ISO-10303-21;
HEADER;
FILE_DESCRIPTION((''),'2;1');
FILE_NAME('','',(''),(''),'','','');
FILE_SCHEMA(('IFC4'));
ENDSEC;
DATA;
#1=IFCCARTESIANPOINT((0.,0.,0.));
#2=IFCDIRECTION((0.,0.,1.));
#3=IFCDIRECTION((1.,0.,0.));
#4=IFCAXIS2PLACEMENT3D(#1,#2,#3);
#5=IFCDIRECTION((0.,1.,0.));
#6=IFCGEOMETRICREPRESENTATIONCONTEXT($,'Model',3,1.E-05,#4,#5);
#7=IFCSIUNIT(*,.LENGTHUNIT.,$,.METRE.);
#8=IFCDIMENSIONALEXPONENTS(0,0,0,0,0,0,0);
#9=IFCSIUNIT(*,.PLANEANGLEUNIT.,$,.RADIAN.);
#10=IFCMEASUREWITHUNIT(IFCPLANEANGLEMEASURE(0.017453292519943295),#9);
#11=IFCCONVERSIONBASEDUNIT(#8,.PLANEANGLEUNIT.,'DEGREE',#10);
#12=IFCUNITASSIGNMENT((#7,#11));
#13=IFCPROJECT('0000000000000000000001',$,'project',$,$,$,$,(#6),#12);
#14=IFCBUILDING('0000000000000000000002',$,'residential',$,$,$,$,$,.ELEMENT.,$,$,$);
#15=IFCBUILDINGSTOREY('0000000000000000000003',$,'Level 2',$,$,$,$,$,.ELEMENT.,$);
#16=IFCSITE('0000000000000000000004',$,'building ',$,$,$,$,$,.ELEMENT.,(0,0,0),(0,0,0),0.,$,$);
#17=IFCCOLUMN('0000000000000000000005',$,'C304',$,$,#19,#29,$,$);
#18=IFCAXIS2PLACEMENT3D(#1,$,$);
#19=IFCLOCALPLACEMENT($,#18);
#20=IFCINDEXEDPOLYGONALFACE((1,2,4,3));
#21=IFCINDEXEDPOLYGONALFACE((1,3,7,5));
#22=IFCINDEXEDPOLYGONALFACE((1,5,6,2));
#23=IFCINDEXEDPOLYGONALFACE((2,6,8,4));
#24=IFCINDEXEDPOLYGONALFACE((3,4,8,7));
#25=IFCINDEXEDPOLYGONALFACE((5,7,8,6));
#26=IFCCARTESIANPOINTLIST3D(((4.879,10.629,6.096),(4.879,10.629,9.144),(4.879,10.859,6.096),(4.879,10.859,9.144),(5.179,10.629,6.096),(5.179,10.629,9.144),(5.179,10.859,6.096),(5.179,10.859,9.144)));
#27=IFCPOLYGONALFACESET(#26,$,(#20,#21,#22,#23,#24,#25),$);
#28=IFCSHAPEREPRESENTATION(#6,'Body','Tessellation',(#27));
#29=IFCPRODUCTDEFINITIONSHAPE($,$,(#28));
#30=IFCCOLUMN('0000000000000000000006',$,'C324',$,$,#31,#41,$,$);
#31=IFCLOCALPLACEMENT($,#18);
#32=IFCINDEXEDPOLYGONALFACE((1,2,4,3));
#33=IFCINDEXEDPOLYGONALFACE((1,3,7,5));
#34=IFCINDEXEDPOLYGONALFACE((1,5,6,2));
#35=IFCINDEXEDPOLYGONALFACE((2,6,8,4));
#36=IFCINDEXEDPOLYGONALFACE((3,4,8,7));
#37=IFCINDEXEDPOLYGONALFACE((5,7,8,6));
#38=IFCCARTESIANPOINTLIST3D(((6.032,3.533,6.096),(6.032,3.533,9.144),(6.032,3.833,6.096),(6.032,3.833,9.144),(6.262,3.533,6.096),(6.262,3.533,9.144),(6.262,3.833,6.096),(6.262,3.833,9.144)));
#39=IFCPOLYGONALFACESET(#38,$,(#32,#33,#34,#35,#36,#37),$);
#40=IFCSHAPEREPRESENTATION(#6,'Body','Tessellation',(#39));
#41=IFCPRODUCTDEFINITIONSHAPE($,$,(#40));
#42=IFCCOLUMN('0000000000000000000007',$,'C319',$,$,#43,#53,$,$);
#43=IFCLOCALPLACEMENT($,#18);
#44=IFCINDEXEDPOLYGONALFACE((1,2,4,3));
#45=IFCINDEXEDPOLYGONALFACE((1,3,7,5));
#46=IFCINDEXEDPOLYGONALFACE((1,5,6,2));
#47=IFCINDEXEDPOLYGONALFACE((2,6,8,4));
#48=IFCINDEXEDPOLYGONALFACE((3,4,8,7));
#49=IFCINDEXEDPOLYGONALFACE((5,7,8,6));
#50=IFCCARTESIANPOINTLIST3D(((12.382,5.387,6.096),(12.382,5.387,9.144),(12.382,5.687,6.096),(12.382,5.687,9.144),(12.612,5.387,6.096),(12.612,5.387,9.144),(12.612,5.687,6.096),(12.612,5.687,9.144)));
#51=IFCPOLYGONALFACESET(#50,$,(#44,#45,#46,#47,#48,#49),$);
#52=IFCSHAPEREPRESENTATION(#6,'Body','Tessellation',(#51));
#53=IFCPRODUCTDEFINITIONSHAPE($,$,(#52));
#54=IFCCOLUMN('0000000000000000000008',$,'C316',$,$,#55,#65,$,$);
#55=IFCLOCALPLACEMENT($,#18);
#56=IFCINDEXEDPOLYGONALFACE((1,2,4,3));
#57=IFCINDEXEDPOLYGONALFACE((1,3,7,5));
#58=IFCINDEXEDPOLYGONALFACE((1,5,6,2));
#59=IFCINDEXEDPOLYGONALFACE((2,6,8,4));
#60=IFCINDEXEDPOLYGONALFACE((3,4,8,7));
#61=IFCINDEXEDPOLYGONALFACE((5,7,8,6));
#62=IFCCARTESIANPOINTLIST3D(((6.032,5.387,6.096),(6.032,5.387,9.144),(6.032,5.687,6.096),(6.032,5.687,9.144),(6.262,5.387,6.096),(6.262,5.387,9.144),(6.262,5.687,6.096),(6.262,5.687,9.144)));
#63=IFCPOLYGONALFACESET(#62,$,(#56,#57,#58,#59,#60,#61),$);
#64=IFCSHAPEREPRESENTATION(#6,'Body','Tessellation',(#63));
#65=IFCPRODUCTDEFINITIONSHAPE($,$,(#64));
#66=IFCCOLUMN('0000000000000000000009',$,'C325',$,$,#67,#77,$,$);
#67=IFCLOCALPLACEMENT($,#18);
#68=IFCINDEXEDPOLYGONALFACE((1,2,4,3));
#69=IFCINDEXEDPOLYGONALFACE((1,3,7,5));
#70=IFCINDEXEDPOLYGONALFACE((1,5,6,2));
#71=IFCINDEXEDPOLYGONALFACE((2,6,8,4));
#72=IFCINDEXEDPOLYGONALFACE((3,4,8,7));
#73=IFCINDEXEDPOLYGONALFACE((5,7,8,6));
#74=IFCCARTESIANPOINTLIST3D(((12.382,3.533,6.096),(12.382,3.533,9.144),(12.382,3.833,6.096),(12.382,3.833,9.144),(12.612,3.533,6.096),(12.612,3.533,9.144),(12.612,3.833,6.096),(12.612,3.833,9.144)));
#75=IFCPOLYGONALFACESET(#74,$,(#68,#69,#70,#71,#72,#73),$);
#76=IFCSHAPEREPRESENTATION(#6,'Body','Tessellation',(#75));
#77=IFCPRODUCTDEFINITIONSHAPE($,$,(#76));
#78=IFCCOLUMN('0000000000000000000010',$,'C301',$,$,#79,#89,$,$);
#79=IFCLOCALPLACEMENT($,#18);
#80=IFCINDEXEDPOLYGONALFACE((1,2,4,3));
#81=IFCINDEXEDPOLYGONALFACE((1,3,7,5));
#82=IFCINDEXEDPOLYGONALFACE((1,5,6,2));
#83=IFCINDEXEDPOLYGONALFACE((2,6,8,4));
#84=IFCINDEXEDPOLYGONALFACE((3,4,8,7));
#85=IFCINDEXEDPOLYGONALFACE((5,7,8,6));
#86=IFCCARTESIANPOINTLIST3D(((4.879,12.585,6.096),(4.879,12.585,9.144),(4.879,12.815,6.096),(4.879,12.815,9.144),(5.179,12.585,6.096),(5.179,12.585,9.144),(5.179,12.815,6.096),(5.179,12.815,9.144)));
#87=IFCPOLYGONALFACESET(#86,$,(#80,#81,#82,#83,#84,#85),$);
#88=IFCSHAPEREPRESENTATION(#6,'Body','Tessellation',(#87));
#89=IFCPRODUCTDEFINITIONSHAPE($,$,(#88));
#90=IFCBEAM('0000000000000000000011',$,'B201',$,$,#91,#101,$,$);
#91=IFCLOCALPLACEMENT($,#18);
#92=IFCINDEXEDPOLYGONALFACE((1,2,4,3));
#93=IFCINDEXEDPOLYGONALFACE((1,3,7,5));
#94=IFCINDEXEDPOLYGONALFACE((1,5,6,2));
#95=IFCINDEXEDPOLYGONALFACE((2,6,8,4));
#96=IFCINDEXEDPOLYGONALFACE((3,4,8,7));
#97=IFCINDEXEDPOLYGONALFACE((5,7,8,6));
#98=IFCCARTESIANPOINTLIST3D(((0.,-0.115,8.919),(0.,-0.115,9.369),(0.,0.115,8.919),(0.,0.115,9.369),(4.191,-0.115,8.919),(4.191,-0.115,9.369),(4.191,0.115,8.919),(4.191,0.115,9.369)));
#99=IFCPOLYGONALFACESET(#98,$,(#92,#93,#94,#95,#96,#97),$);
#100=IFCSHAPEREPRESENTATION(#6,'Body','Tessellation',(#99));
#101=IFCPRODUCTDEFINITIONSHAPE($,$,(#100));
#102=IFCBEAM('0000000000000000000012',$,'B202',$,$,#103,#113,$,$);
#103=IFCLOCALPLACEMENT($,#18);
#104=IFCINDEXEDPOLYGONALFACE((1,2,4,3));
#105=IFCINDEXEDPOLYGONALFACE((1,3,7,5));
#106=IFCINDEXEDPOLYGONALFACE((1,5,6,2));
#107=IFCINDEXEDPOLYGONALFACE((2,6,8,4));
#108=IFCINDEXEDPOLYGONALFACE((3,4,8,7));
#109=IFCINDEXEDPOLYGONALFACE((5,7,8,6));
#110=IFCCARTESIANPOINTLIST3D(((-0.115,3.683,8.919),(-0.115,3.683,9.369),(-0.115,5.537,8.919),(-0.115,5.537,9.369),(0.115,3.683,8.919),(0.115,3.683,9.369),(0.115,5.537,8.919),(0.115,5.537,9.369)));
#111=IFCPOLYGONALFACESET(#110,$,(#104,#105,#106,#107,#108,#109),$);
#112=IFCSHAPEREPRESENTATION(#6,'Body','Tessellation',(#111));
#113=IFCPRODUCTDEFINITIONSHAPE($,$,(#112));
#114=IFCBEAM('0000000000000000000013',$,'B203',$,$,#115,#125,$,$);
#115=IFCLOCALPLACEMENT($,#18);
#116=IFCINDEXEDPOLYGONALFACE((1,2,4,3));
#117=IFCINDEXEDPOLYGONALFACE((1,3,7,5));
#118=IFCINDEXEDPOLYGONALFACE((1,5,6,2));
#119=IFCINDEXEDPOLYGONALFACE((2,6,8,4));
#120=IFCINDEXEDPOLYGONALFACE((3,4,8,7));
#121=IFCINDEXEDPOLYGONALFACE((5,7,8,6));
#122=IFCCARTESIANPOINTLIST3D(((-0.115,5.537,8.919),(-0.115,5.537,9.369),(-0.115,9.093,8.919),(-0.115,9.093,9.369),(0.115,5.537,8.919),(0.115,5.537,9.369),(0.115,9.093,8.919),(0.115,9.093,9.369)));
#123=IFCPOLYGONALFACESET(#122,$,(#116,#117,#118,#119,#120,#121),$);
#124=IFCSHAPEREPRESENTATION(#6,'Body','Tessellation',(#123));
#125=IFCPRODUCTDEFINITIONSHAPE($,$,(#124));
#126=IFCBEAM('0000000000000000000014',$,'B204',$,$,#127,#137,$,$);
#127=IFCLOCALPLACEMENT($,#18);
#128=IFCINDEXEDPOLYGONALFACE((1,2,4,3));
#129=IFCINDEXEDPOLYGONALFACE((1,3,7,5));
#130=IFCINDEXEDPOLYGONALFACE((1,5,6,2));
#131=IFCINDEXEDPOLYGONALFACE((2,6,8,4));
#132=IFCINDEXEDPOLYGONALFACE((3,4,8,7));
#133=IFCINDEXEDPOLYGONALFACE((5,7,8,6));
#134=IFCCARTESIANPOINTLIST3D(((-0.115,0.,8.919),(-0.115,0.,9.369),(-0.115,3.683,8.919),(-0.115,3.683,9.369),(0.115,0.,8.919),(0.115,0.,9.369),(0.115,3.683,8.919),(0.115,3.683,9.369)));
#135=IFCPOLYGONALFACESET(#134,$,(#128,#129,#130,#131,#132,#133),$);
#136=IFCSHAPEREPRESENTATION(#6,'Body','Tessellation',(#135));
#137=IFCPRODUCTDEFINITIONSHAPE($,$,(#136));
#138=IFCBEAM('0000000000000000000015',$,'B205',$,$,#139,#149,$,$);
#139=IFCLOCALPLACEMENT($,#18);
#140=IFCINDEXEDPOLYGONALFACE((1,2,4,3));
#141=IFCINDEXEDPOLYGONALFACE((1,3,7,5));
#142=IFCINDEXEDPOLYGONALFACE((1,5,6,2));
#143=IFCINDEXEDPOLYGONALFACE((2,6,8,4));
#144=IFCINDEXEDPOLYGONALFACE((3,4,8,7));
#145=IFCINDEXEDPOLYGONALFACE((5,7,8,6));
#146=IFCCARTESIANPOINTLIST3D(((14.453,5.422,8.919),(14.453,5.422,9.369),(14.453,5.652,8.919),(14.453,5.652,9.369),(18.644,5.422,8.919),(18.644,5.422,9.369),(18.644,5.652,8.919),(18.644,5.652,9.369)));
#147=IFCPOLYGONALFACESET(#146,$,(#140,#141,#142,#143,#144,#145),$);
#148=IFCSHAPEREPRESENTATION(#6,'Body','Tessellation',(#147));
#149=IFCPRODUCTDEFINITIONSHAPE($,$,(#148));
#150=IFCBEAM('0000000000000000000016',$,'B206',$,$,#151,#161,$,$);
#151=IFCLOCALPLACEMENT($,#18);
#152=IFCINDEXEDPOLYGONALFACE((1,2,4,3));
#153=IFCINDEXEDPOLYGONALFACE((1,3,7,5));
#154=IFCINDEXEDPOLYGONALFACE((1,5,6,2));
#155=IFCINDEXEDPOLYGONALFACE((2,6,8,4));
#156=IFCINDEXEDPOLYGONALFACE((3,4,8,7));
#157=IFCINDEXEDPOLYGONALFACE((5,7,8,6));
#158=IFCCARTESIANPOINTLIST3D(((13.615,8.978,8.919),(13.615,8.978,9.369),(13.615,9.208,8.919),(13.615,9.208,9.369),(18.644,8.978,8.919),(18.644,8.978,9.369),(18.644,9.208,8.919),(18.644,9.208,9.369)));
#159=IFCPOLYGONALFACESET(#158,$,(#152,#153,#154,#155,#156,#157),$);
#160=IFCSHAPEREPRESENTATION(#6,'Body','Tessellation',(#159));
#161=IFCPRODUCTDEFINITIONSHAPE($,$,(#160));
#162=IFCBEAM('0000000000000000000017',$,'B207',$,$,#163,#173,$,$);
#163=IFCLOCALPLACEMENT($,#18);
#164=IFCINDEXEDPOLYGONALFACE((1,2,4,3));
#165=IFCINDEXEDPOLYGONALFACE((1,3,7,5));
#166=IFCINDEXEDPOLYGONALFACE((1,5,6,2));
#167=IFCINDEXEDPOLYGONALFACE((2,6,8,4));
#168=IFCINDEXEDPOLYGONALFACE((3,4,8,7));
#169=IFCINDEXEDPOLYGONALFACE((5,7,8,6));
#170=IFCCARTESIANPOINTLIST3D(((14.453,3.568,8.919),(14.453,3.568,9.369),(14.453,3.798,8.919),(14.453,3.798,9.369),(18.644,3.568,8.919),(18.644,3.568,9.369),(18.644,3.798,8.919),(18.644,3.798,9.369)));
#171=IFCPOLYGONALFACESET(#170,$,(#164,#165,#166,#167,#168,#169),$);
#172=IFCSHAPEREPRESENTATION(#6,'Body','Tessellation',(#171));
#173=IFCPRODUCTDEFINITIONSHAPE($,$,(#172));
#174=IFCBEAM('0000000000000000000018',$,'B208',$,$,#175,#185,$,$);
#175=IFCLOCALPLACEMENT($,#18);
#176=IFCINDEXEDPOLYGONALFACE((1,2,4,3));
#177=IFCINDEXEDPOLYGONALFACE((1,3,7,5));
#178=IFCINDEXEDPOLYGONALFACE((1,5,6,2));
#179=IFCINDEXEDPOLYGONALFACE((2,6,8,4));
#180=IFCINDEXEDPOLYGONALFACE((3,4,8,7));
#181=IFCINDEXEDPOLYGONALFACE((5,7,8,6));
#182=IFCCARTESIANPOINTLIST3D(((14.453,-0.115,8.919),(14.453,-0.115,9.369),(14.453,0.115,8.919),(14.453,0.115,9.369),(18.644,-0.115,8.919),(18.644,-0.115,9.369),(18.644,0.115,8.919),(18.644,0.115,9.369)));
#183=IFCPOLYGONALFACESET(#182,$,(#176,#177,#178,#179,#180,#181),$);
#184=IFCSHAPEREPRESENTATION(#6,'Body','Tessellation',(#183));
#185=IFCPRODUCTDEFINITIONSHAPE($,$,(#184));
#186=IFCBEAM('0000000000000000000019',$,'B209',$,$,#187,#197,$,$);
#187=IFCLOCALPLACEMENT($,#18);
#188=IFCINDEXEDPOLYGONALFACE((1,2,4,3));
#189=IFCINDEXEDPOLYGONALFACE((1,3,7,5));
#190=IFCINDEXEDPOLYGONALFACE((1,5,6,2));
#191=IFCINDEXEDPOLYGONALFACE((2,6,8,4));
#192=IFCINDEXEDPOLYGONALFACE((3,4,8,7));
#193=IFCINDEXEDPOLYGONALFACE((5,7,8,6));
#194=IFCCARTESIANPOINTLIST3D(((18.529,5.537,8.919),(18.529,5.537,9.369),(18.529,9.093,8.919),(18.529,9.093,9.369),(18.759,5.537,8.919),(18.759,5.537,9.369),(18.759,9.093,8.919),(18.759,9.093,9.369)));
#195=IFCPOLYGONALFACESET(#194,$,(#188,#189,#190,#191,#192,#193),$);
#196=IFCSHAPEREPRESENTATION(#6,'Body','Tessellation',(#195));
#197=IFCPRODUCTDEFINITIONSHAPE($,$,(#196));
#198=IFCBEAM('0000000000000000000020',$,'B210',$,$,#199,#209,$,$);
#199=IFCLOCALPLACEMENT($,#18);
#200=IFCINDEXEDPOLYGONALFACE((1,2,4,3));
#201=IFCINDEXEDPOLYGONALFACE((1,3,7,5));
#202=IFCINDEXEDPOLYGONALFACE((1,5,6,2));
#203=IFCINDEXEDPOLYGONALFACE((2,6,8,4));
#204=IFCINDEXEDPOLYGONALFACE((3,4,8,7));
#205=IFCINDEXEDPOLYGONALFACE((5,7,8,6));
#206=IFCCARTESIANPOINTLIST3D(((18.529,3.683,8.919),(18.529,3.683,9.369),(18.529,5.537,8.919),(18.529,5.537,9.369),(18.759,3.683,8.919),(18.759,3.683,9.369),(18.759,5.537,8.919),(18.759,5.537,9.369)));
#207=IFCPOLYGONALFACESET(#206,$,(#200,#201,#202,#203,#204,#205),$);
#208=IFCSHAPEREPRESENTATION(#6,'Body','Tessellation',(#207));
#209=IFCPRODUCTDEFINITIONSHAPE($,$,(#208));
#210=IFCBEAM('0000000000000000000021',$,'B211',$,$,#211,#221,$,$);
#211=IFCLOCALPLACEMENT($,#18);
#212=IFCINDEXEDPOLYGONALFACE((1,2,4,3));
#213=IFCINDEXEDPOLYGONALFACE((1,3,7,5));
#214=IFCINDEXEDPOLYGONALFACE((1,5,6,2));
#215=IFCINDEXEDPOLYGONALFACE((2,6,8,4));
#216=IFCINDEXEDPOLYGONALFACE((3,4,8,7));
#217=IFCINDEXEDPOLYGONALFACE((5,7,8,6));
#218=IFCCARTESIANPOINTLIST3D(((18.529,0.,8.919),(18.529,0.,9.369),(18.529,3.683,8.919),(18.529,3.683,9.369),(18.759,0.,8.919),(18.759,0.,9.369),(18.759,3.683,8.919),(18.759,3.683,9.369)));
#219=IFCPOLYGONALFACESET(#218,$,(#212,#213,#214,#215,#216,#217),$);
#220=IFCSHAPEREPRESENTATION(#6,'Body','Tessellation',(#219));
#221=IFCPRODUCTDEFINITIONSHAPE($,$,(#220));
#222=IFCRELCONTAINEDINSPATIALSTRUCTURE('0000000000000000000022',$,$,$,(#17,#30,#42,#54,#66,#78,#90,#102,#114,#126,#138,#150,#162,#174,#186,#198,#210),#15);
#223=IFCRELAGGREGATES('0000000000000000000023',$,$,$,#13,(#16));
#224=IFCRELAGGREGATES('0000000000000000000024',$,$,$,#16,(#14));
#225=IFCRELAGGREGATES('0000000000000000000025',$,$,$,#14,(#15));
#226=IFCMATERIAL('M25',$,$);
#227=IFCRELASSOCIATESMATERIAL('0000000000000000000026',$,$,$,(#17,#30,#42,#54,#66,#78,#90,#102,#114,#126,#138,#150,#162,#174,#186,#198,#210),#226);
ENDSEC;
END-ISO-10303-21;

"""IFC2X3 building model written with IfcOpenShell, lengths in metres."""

from ifc_helpers import new_model, entity, si_unit, converted_unit, direction, frame, frame_2d, origin_with_axes, place, context, project, spatial, rectangle, extrude, material, element, save


model = new_model("IFC2X3")

# Units and contexts
model_context = context("Model", 3, precision=1e-05, world=origin_with_axes(), true_north=direction((0.0, 1.0, 0.0)))
ifc_project = project(units=[si_unit("LENGTHUNIT", "METRE"), converted_unit("PLANEANGLEUNIT", "DEGREE", entity("IfcPlaneAngleMeasure", 0.017453292519943295), si_unit("PLANEANGLEUNIT", "RADIAN"), dimensions=[0, 0, 0, 0, 0, 0, 0])], contexts=[model_context])

# Site, building, storey
site = spatial("IfcSite", under=ifc_project, Name="building ", CompositionType="ELEMENT", RefLatitude=(0, 0, 0), RefLongitude=(0, 0, 0), RefElevation=0.0)
building = spatial("IfcBuilding", under=site, Name="residential", CompositionType="ELEMENT")
storey = spatial("IfcBuildingStorey", under=building, Name="Level 2", CompositionType="ELEMENT")

# Columns
ifc_material = material(Name="M25")
placement = place(None, origin_with_axes())
element("IfcColumn", 1, at=placement, inside=storey, material=ifc_material, Name="C304", context=model_context, shape_type="SweptSolid", body=[
    extrude(rectangle(XDim=0.3, YDim=0.23, at=frame_2d((0.0, 0.0), x_axis=(1.0, 0.0, 0.0))), frame((5.029, 10.744, 6.096), z_axis=(0.0, 0.0, 1.0), x_axis=(1.0, 0.0, 0.0)), (0.0, 0.0, 1.0), 3.048),
])
element("IfcColumn", 2, at=placement, inside=storey, material=ifc_material, Name="C324", context=model_context, shape_type="SweptSolid", body=[
    extrude(rectangle(XDim=0.23, YDim=0.3, at=frame_2d((0.0, 0.0), x_axis=(1.0, 0.0, 0.0))), frame((6.147, 3.683, 6.096), z_axis=(0.0, 0.0, 1.0), x_axis=(1.0, 0.0, 0.0)), (0.0, 0.0, 1.0), 3.048),
])
element("IfcColumn", 3, at=placement, inside=storey, material=ifc_material, Name="C319", context=model_context, shape_type="SweptSolid", body=[
    extrude(rectangle(XDim=0.23, YDim=0.3, at=frame_2d((0.0, 0.0), x_axis=(1.0, 0.0, 0.0))), frame((12.497, 5.537, 6.096), z_axis=(0.0, 0.0, 1.0), x_axis=(1.0, 0.0, 0.0)), (0.0, 0.0, 1.0), 3.048),
])
element("IfcColumn", 4, at=placement, inside=storey, material=ifc_material, Name="C316", context=model_context, shape_type="SweptSolid", body=[
    extrude(rectangle(XDim=0.23, YDim=0.3, at=frame_2d((0.0, 0.0), x_axis=(1.0, 0.0, 0.0))), frame((6.147, 5.537, 6.096), z_axis=(0.0, 0.0, 1.0), x_axis=(1.0, 0.0, 0.0)), (0.0, 0.0, 1.0), 3.048),
])
element("IfcColumn", 5, at=placement, inside=storey, material=ifc_material, Name="C325", context=model_context, shape_type="SweptSolid", body=[
    extrude(rectangle(XDim=0.23, YDim=0.3, at=frame_2d((0.0, 0.0), x_axis=(1.0, 0.0, 0.0))), frame((12.497, 3.683, 6.096), z_axis=(0.0, 0.0, 1.0), x_axis=(1.0, 0.0, 0.0)), (0.0, 0.0, 1.0), 3.048),
])
element("IfcColumn", 6, at=placement, inside=storey, material=ifc_material, Name="C301", context=model_context, shape_type="SweptSolid", body=[
    extrude(rectangle(XDim=0.3, YDim=0.23, at=frame_2d((0.0, 0.0), x_axis=(1.0, 0.0, 0.0))), frame((5.029, 12.7, 6.096), z_axis=(0.0, 0.0, 1.0), x_axis=(1.0, 0.0, 0.0)), (0.0, 0.0, 1.0), 3.048),
])

# Beams
element("IfcBeam", 7, at=placement, inside=storey, material=ifc_material, Name="B201", context=model_context, shape_type="SweptSolid", body=[
    extrude(rectangle(XDim=0.23, YDim=0.45, at=frame_2d((0.0, 0.0), x_axis=(0.0, 1.0, 0.0))), frame((0.0, 0.0, 9.144), z_axis=(1.0, 0.0, 0.0), x_axis=(0.0, 0.0, -1.0)), (0.0, 0.0, 1.0), 4.191),
])
element("IfcBeam", 8, at=placement, inside=storey, material=ifc_material, Name="B202", context=model_context, shape_type="SweptSolid", body=[
    extrude(rectangle(XDim=0.23, YDim=0.45, at=frame_2d((0.0, 0.0), x_axis=(0.0, 1.0, 0.0))), frame((0.0, 3.683, 9.144), z_axis=(0.0, 1.0, 0.0), x_axis=(0.0, 0.0, -1.0)), (0.0, 0.0, 1.0), 1.854),
])
element("IfcBeam", 9, at=placement, inside=storey, material=ifc_material, Name="B203", context=model_context, shape_type="SweptSolid", body=[
    extrude(rectangle(XDim=0.23, YDim=0.45, at=frame_2d((0.0, 0.0), x_axis=(0.0, 1.0, 0.0))), frame((0.0, 5.537, 9.144), z_axis=(0.0, 1.0, 0.0), x_axis=(0.0, 0.0, -1.0)), (0.0, 0.0, 1.0), 3.556),
])
element("IfcBeam", 10, at=placement, inside=storey, material=ifc_material, Name="B204", context=model_context, shape_type="SweptSolid", body=[
    extrude(rectangle(XDim=0.23, YDim=0.45, at=frame_2d((0.0, 0.0), x_axis=(0.0, 1.0, 0.0))), frame((0.0, 0.0, 9.144), z_axis=(0.0, 1.0, 0.0), x_axis=(0.0, 0.0, -1.0)), (0.0, 0.0, 1.0), 3.683),
])
element("IfcBeam", 11, at=placement, inside=storey, material=ifc_material, Name="B205", context=model_context, shape_type="SweptSolid", body=[
    extrude(rectangle(XDim=0.23, YDim=0.45, at=frame_2d((0.0, 0.0), x_axis=(0.0, 1.0, 0.0))), frame((18.644, 5.537, 9.144), z_axis=(-1.0, 0.0, 0.0), x_axis=(0.0, 0.0, -1.0)), (0.0, 0.0, 1.0), 4.191),
])
element("IfcBeam", 12, at=placement, inside=storey, material=ifc_material, Name="B206", context=model_context, shape_type="SweptSolid", body=[
    extrude(rectangle(XDim=0.23, YDim=0.45, at=frame_2d((0.0, 0.0), x_axis=(0.0, 1.0, 0.0))), frame((18.644, 9.093, 9.144), z_axis=(-1.0, 0.0, 0.0), x_axis=(0.0, 0.0, -1.0)), (0.0, 0.0, 1.0), 5.029),
])
element("IfcBeam", 13, at=placement, inside=storey, material=ifc_material, Name="B207", context=model_context, shape_type="SweptSolid", body=[
    extrude(rectangle(XDim=0.23, YDim=0.45, at=frame_2d((0.0, 0.0), x_axis=(0.0, 1.0, 0.0))), frame((18.644, 3.683, 9.144), z_axis=(-1.0, 0.0, 0.0), x_axis=(0.0, 0.0, -1.0)), (0.0, 0.0, 1.0), 4.191),
])
element("IfcBeam", 14, at=placement, inside=storey, material=ifc_material, Name="B208", context=model_context, shape_type="SweptSolid", body=[
    extrude(rectangle(XDim=0.23, YDim=0.45, at=frame_2d((0.0, 0.0), x_axis=(0.0, 1.0, 0.0))), frame((18.644, 0.0, 9.144), z_axis=(-1.0, 0.0, 0.0), x_axis=(0.0, 0.0, -1.0)), (0.0, 0.0, 1.0), 4.191),
])
element("IfcBeam", 15, at=placement, inside=storey, material=ifc_material, Name="B209", context=model_context, shape_type="SweptSolid", body=[
    extrude(rectangle(XDim=0.23, YDim=0.45, at=frame_2d((0.0, 0.0), x_axis=(0.0, 1.0, 0.0))), frame((18.644, 9.093, 9.144), z_axis=(0.0, -1.0, 0.0), x_axis=(0.0, 0.0, -1.0)), (0.0, 0.0, 1.0), 3.556),
])
element("IfcBeam", 16, at=placement, inside=storey, material=ifc_material, Name="B210", context=model_context, shape_type="SweptSolid", body=[
    extrude(rectangle(XDim=0.23, YDim=0.45, at=frame_2d((0.0, 0.0), x_axis=(0.0, 1.0, 0.0))), frame((18.644, 3.683, 9.144), z_axis=(0.0, 1.0, 0.0), x_axis=(0.0, 0.0, -1.0)), (0.0, 0.0, 1.0), 1.854),
])
element("IfcBeam", 17, at=placement, inside=storey, material=ifc_material, Name="B211", context=model_context, shape_type="SweptSolid", body=[
    extrude(rectangle(XDim=0.23, YDim=0.45, at=frame_2d((0.0, 0.0), x_axis=(0.0, 1.0, 0.0))), frame((18.644, 0.0, 9.144), z_axis=(0.0, 1.0, 0.0), x_axis=(0.0, 0.0, -1.0)), (0.0, 0.0, 1.0), 3.683),
])

save(model, "model.ifc")
